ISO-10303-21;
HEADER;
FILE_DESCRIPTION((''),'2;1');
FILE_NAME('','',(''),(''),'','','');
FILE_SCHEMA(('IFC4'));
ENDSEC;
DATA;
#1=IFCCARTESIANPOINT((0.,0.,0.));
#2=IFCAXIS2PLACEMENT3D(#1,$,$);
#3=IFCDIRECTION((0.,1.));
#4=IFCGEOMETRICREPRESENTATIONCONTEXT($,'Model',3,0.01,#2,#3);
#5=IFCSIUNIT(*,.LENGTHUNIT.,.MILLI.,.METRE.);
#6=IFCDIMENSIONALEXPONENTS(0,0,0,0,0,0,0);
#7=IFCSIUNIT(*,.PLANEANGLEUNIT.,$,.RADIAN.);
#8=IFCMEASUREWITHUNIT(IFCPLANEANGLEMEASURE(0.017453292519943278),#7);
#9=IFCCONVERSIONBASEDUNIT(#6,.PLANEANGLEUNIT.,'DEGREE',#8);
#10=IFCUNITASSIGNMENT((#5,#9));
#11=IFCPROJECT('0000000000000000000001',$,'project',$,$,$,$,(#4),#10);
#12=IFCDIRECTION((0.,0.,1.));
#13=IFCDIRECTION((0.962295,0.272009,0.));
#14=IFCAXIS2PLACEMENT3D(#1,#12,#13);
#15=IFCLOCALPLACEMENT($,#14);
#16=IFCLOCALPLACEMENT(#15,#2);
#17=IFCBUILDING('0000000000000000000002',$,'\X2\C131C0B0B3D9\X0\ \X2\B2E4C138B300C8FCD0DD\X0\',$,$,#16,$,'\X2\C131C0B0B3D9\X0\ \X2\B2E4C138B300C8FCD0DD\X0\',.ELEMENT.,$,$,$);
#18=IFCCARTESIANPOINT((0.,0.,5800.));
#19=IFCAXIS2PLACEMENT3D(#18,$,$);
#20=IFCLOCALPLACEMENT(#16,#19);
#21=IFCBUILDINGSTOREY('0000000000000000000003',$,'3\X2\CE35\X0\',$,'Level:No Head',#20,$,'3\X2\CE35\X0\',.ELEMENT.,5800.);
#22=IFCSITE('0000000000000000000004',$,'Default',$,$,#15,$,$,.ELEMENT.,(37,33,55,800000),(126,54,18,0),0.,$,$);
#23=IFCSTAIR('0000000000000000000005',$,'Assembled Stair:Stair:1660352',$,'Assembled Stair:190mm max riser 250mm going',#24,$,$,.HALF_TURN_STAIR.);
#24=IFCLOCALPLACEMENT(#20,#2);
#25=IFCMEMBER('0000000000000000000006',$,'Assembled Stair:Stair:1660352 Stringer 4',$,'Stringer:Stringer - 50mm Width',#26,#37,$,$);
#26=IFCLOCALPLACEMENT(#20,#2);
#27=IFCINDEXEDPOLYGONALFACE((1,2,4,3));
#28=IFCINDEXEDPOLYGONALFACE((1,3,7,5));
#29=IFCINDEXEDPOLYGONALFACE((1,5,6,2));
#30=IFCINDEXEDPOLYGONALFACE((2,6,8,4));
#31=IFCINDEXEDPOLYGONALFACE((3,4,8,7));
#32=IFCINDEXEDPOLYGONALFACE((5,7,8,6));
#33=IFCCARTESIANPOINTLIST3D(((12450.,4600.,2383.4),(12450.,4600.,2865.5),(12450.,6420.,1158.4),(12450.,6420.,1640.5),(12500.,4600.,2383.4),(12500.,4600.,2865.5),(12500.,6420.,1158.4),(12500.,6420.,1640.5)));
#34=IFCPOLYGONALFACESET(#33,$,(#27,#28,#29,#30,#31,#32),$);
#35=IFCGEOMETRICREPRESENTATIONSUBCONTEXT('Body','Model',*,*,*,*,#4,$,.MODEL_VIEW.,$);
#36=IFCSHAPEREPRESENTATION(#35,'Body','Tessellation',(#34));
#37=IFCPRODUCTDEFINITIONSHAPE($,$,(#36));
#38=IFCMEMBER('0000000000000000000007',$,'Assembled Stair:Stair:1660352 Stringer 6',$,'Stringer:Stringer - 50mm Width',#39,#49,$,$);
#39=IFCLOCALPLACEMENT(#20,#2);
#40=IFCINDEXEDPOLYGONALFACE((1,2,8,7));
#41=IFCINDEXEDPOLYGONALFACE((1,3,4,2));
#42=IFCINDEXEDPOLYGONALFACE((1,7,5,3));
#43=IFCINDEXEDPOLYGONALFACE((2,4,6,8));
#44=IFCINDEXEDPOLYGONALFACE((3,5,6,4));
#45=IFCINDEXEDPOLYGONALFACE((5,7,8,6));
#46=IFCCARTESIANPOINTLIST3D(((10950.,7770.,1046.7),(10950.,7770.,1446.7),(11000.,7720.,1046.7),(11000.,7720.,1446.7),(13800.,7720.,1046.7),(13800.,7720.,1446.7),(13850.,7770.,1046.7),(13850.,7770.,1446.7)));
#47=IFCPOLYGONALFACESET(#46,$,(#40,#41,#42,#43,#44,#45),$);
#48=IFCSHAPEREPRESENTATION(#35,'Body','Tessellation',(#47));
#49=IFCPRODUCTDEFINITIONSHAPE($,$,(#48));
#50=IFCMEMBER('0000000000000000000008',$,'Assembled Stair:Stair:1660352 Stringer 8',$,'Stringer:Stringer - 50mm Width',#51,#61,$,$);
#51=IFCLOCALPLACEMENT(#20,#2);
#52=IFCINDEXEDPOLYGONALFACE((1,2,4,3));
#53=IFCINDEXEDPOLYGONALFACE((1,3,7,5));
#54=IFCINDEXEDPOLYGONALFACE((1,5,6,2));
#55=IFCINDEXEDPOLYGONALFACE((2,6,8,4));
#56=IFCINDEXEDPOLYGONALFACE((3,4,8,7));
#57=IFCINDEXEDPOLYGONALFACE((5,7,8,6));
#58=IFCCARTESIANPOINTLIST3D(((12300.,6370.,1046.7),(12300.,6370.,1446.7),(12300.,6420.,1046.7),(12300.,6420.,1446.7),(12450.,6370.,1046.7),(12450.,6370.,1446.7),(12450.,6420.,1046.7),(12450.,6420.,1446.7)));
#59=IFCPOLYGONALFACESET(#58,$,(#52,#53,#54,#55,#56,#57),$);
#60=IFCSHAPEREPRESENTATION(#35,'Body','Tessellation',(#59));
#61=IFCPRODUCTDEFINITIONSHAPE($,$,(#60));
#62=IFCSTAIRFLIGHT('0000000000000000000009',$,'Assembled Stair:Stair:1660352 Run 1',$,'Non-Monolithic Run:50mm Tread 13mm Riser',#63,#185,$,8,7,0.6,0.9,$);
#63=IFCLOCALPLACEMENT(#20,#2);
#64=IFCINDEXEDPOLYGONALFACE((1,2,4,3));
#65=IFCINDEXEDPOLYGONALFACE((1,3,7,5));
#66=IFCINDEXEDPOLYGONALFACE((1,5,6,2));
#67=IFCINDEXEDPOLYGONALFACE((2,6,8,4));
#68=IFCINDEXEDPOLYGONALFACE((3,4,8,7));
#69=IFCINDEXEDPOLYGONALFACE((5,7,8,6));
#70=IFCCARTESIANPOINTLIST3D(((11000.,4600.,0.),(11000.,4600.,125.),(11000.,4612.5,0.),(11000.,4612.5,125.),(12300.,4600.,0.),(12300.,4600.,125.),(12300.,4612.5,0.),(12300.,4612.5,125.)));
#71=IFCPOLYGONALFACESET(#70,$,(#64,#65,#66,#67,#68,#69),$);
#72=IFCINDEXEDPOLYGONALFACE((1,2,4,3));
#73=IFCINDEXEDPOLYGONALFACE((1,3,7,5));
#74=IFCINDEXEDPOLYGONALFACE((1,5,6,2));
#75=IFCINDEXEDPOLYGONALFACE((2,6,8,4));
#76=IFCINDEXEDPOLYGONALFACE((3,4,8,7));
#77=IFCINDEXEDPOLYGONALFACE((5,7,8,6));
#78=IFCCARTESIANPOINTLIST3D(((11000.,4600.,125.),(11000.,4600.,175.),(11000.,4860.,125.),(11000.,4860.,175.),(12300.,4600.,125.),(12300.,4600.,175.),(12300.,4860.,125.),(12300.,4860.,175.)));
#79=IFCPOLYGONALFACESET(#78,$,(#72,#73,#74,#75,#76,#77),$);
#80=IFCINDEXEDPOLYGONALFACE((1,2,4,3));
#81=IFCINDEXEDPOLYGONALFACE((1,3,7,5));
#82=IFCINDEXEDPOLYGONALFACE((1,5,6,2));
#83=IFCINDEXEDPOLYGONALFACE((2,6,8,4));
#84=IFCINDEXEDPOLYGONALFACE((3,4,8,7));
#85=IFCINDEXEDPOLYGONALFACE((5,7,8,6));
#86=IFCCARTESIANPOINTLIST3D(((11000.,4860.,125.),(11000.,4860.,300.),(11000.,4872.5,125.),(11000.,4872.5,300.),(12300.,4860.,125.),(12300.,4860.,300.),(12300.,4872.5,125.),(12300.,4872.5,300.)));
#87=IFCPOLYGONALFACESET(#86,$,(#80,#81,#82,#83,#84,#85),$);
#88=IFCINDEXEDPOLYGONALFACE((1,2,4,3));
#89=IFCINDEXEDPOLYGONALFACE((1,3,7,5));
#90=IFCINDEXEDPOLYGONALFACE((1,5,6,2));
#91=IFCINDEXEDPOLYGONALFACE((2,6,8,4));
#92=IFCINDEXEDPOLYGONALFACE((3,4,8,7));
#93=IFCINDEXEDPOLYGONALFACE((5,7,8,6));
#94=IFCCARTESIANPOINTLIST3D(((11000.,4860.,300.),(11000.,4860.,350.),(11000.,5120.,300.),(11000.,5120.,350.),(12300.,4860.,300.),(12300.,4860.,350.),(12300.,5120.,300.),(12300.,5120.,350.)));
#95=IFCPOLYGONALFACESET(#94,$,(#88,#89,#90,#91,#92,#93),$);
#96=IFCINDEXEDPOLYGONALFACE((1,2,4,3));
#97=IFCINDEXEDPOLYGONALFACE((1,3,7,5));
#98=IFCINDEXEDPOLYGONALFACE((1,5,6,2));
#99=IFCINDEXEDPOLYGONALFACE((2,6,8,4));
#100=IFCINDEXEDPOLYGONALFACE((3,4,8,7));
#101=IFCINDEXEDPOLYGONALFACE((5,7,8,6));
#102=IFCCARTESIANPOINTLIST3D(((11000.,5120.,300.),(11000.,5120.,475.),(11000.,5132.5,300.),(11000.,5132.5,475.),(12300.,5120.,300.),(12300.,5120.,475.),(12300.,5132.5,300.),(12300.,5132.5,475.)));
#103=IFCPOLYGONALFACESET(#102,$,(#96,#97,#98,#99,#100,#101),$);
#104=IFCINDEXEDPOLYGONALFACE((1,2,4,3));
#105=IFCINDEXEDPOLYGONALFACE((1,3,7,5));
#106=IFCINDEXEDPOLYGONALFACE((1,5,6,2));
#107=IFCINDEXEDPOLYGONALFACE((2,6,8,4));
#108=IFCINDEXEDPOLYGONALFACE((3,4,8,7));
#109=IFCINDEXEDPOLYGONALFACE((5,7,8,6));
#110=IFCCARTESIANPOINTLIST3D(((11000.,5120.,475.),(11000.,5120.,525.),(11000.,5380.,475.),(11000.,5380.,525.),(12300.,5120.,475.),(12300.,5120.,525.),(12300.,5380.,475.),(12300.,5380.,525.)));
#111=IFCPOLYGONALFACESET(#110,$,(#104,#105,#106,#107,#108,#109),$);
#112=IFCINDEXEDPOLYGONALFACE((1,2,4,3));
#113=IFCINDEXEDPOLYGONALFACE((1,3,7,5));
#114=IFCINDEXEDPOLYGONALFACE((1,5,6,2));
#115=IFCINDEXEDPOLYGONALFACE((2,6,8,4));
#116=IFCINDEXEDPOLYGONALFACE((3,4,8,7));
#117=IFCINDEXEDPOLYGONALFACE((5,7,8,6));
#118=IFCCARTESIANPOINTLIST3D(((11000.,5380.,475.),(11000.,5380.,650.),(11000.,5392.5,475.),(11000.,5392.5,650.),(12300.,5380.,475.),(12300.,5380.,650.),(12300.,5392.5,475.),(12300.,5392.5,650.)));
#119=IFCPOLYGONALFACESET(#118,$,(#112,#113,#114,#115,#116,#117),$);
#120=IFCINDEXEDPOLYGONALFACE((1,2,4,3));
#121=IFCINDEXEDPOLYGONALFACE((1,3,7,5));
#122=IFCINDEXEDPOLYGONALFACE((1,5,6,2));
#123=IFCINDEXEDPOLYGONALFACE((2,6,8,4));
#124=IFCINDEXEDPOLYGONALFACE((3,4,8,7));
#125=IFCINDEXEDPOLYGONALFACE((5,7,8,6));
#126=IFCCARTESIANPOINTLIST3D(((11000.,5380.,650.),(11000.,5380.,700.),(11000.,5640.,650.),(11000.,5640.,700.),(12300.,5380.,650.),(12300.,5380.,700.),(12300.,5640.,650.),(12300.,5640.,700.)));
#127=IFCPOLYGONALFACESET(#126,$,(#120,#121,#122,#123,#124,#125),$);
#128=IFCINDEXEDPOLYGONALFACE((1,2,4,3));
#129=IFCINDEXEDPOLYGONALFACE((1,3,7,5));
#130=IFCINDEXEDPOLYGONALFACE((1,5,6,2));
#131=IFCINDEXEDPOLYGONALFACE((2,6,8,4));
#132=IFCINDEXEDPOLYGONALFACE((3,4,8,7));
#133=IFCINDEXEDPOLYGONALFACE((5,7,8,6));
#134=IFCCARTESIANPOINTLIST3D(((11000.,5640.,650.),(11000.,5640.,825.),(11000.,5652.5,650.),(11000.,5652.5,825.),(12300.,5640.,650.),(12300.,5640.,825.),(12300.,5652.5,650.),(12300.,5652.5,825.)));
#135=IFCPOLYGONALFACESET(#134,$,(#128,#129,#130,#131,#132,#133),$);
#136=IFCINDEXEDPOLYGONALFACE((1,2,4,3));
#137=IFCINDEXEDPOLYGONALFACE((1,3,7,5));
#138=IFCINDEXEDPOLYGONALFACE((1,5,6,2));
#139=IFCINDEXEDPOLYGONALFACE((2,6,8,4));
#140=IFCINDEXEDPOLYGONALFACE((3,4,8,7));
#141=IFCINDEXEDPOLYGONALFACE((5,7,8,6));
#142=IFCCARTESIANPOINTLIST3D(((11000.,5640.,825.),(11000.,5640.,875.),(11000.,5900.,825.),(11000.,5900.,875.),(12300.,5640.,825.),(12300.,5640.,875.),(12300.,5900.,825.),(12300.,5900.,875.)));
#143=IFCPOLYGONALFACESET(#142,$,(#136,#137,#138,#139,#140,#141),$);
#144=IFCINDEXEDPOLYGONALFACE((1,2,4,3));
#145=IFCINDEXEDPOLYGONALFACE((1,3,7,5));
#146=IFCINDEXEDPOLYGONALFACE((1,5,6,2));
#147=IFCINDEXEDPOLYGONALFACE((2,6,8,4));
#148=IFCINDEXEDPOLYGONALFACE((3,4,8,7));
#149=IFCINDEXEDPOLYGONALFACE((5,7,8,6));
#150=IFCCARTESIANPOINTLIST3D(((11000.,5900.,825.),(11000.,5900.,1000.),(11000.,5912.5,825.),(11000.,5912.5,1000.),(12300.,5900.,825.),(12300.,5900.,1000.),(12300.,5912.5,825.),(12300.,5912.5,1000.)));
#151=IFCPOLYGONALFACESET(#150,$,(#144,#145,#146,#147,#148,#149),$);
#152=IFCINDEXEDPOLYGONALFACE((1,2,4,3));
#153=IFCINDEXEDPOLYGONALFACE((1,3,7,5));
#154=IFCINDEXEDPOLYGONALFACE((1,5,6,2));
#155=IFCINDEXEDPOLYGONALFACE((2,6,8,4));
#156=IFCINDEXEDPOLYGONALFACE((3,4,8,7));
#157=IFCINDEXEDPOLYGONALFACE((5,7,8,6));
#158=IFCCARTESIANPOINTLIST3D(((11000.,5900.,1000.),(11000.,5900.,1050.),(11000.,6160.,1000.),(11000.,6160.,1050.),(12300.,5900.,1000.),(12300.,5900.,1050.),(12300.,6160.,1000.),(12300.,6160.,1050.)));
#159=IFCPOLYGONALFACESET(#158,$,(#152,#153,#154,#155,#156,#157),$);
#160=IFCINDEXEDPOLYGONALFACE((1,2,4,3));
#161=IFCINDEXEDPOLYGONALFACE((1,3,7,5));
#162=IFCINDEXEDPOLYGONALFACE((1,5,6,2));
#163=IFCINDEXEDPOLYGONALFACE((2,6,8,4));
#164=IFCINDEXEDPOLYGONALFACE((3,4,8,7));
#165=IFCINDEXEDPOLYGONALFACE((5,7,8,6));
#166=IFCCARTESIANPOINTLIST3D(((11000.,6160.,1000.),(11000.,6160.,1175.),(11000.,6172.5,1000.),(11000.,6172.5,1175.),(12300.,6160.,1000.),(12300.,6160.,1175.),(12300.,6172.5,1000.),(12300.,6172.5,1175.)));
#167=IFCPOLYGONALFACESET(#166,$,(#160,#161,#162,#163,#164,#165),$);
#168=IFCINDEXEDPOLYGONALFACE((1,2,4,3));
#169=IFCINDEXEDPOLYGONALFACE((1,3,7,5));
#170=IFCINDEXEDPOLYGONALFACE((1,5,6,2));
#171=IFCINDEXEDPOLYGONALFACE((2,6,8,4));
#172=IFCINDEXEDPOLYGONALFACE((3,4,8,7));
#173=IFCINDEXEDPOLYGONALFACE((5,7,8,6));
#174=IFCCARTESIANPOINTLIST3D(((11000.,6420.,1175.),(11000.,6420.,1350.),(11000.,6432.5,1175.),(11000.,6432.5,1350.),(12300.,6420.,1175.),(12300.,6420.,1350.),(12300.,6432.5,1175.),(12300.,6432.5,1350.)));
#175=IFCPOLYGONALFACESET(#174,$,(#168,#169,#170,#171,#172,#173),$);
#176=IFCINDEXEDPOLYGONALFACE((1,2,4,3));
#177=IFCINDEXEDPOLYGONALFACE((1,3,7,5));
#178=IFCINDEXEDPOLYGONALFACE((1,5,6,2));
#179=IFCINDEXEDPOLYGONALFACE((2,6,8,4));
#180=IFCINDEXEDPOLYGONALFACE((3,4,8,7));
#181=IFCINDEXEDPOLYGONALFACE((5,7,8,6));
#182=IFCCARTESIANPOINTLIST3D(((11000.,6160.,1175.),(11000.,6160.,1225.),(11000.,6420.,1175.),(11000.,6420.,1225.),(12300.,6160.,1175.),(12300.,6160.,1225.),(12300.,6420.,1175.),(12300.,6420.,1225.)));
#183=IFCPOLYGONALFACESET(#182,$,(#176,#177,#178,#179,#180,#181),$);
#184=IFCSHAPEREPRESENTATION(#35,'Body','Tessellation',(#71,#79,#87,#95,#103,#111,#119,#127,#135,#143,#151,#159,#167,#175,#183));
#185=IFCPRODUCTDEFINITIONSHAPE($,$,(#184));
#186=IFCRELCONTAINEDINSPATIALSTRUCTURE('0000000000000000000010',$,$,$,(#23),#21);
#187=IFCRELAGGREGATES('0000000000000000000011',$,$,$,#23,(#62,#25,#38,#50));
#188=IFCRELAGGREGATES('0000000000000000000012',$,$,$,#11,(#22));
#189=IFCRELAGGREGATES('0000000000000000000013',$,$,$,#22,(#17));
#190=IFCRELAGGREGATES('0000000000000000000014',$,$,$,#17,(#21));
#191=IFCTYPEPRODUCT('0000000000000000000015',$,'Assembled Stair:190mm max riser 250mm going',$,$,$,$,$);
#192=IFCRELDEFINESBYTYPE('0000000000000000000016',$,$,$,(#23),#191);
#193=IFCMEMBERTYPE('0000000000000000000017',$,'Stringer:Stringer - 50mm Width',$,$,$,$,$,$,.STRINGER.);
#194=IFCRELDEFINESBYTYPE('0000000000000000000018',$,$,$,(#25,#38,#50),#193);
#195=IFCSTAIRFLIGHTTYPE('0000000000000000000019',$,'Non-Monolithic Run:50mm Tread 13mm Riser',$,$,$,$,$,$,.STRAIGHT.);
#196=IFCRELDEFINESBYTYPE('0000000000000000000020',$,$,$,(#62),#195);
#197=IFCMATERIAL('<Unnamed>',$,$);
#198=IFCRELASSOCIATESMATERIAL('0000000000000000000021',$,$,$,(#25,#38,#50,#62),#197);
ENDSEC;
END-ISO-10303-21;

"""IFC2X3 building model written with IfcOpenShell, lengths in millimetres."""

from ifc_helpers import new_model, entity, si_unit, converted_unit, direction, frame, frame_2d, origin, origin_2d_with_axis, place, context, subcontext, project, spatial, polyline, rectangle, outline, extrude, material, type_object, element, aggregate, save


model = new_model("IFC2X3")

# Units and contexts
model_context = context("Model", 3, precision=0.01, world=origin(), true_north=direction((0.0, 1.0)))
body_context = subcontext(model_context, "Body", "Model", "MODEL_VIEW")
ifc_project = project(units=[si_unit("LENGTHUNIT", "METRE", prefix="MILLI"), converted_unit("PLANEANGLEUNIT", "DEGREE", entity("IfcPlaneAngleMeasure", 0.017453292519943278), si_unit("PLANEANGLEUNIT", "RADIAN"), dimensions=[0, 0, 0, 0, 0, 0, 0])], contexts=[model_context])

# Site, building, storey
site_placement = place(None, frame((0.0, 0.0, 0.0), z_axis=(0.0, 0.0, 1.0), x_axis=(0.962295, 0.272009, 0.0)))
site = spatial("IfcSite", under=ifc_project, at=site_placement, Name="Default", CompositionType="ELEMENT", RefLatitude=(37, 33, 55, 800000), RefLongitude=(126, 54, 18, 0), RefElevation=0.0)
building_placement = place(site_placement, origin())
building = spatial("IfcBuilding", under=site, at=building_placement, Name="성산동 다세대주택", LongName="성산동 다세대주택", CompositionType="ELEMENT")
storey_placement = place(building_placement, frame((0.0, 0.0, 5800.0)))
storey = spatial("IfcBuildingStorey", under=building, at=storey_placement, Name="3층", ObjectType="Level:No Head", LongName="3층", CompositionType="ELEMENT", Elevation=5800.0)

# Stair, members
type_product = type_object("IfcTypeProduct", Name="Assembled Stair:190mm max riser 250mm going")
stair_placement = place(storey_placement, origin())
stair = element("IfcStair", 1, at=stair_placement, inside=storey, type_object=type_product, Name="Assembled Stair:Stair:1660352", ObjectType="Assembled Stair:190mm max riser 250mm going", ShapeType="HALF_TURN_STAIR")
ifc_material_1 = material(Name="<Unnamed>")
member_type = type_object("IfcMemberType", Name="Stringer:Stringer - 50mm Width", PredefinedType="STRINGER")
member_1_placement = place(stair_placement, origin())
member_1 = element("IfcMember", 2, at=member_1_placement, type_object=member_type, material=ifc_material_1, Name="Assembled Stair:Stair:1660352 Stringer 4", ObjectType="Stringer:Stringer - 50mm Width", context=body_context, shape_type="SweptSolid", body=[
    extrude(outline(polyline([(-962.3, -200.0), (1231.5, -200.0), (962.3, 200.0), (-1231.5, 200.0), (-962.3, -200.0)])), frame((12450.0, 5510.0, 2011.9), z_axis=(1.0, 0.0, 0.0), x_axis=(0.0, -0.829588, 0.558376)), (0.0, 0.0, 1.0), 50.0),
])
member_2_placement = place(stair_placement, origin())
member_2 = element("IfcMember", 3, at=member_2_placement, type_object=member_type, material=ifc_material_1, Name="Assembled Stair:Stair:1660352 Stringer 6", ObjectType="Stringer:Stringer - 50mm Width", context=body_context, shape_type="SweptSolid", body=[
    extrude(outline(polyline([(-1450.0, -25.0), (1450.0, -25.0), (1400.0, 25.0), (-1400.0, 25.0), (-1450.0, -25.0)])), frame((12400.0, 7745.0, 1046.7), z_axis=(0.0, 0.0, 1.0), x_axis=(-1.0, 0.0, 0.0)), (0.0, 0.0, 1.0), 400.0),
])
member_3_placement = place(stair_placement, origin())
member_3 = element("IfcMember", 4, at=member_3_placement, type_object=member_type, material=ifc_material_1, Name="Assembled Stair:Stair:1660352 Stringer 8", ObjectType="Stringer:Stringer - 50mm Width", context=body_context, shape_type="SweptSolid", body=[
    extrude(rectangle(XDim=150.0, YDim=50.0, at=origin_2d_with_axis()), frame((12375.0, 6395.0, 1046.7)), (0.0, 0.0, 1.0), 400.0),
])

# Stair flight
stair_flight_type = type_object("IfcStairFlightType", Name="Non-Monolithic Run:50mm Tread 13mm Riser", PredefinedType="STRAIGHT")
stair_flight_1_placement = place(stair_placement, origin())
stair_flight_1 = element("IfcStairFlight", 5, at=stair_flight_1_placement, type_object=stair_flight_type, material=ifc_material_1, Name="Assembled Stair:Stair:1660352 Run 1", ObjectType="Non-Monolithic Run:50mm Tread 13mm Riser", NumberOfRiser=8, NumberOfTreads=7, RiserHeight=0.6, TreadLength=0.9, context=body_context, shape_type="SweptSolid", body=[
    extrude(rectangle(XDim=1300.0, YDim=12.5, at=frame_2d((0.0, 0.0), x_axis=(1.0, 0.0))), frame((11650.0, 4606.2, 0.0), z_axis=(0.0, 0.0, 1.0), x_axis=(-1.0, 0.0, 0.0)), (0.0, 0.0, 1.0), 125.0),
    extrude(rectangle(XDim=260.0, YDim=1300.0, at=frame_2d((0.0, 0.0), x_axis=(1.0, 0.0))), frame((11650.0, 4730.0, 125.0), z_axis=(0.0, 0.0, 1.0), x_axis=(0.0, -1.0, 0.0)), (0.0, 0.0, 1.0), 50.0),
    extrude(rectangle(XDim=1300.0, YDim=12.5, at=frame_2d((0.0, 0.0), x_axis=(1.0, 0.0))), frame((11650.0, 4866.2, 125.0), z_axis=(0.0, 0.0, 1.0), x_axis=(-1.0, 0.0, 0.0)), (0.0, 0.0, 1.0), 175.0),
    extrude(rectangle(XDim=260.0, YDim=1300.0, at=frame_2d((0.0, 0.0), x_axis=(1.0, 0.0))), frame((11650.0, 4990.0, 300.0), z_axis=(0.0, 0.0, 1.0), x_axis=(0.0, -1.0, 0.0)), (0.0, 0.0, 1.0), 50.0),
    extrude(rectangle(XDim=1300.0, YDim=12.5, at=origin_2d_with_axis()), frame((11650.0, 5126.2, 300.0), z_axis=(0.0, 0.0, 1.0), x_axis=(-1.0, 0.0, 0.0)), (0.0, 0.0, 1.0), 175.0),
    extrude(rectangle(XDim=260.0, YDim=1300.0, at=frame_2d((0.0, 0.0), x_axis=(1.0, 0.0))), frame((11650.0, 5250.0, 475.0), z_axis=(0.0, 0.0, 1.0), x_axis=(0.0, -1.0, 0.0)), (0.0, 0.0, 1.0), 50.0),
    extrude(rectangle(XDim=1300.0, YDim=12.5, at=frame_2d((0.0, 0.0), x_axis=(1.0, 0.0))), frame((11650.0, 5386.2, 475.0), z_axis=(0.0, 0.0, 1.0), x_axis=(-1.0, 0.0, 0.0)), (0.0, 0.0, 1.0), 175.0),
    extrude(rectangle(XDim=260.0, YDim=1300.0, at=origin_2d_with_axis()), frame((11650.0, 5510.0, 650.0), z_axis=(0.0, 0.0, 1.0), x_axis=(0.0, -1.0, 0.0)), (0.0, 0.0, 1.0), 50.0),
    extrude(rectangle(XDim=1300.0, YDim=12.5, at=frame_2d((0.0, 0.0), x_axis=(1.0, 0.0))), frame((11650.0, 5646.2, 650.0), z_axis=(0.0, 0.0, 1.0), x_axis=(-1.0, 0.0, 0.0)), (0.0, 0.0, 1.0), 175.0),
    extrude(rectangle(XDim=260.0, YDim=1300.0, at=origin_2d_with_axis()), frame((11650.0, 5770.0, 825.0), z_axis=(0.0, 0.0, 1.0), x_axis=(0.0, -1.0, 0.0)), (0.0, 0.0, 1.0), 50.0),
    extrude(rectangle(XDim=1300.0, YDim=12.5, at=origin_2d_with_axis()), frame((11650.0, 5906.2, 825.0), z_axis=(0.0, 0.0, 1.0), x_axis=(-1.0, 0.0, 0.0)), (0.0, 0.0, 1.0), 175.0),
    extrude(rectangle(XDim=260.0, YDim=1300.0, at=origin_2d_with_axis()), frame((11650.0, 6030.0, 1000.0), z_axis=(0.0, 0.0, 1.0), x_axis=(0.0, -1.0, 0.0)), (0.0, 0.0, 1.0), 50.0),
    extrude(rectangle(XDim=1300.0, YDim=12.5, at=frame_2d((0.0, 0.0), x_axis=(1.0, 0.0))), frame((11650.0, 6166.2, 1000.0), z_axis=(0.0, 0.0, 1.0), x_axis=(-1.0, 0.0, 0.0)), (0.0, 0.0, 1.0), 175.0),
    extrude(rectangle(XDim=1300.0, YDim=12.5, at=frame_2d((0.0, 0.0), x_axis=(1.0, 0.0))), frame((11650.0, 6426.3, 1175.0), z_axis=(0.0, 0.0, 1.0), x_axis=(-1.0, 0.0, 0.0)), (0.0, 0.0, 1.0), 175.0),
    extrude(rectangle(XDim=260.0, YDim=1300.0, at=origin_2d_with_axis()), frame((11650.0, 6290.0, 1175.0), z_axis=(0.0, 0.0, 1.0), x_axis=(0.0, -1.0, 0.0)), (0.0, 0.0, 1.0), 50.0),
])
aggregate(stair, [stair_flight_1, member_1, member_2, member_3])

save(model, "model.ifc")
